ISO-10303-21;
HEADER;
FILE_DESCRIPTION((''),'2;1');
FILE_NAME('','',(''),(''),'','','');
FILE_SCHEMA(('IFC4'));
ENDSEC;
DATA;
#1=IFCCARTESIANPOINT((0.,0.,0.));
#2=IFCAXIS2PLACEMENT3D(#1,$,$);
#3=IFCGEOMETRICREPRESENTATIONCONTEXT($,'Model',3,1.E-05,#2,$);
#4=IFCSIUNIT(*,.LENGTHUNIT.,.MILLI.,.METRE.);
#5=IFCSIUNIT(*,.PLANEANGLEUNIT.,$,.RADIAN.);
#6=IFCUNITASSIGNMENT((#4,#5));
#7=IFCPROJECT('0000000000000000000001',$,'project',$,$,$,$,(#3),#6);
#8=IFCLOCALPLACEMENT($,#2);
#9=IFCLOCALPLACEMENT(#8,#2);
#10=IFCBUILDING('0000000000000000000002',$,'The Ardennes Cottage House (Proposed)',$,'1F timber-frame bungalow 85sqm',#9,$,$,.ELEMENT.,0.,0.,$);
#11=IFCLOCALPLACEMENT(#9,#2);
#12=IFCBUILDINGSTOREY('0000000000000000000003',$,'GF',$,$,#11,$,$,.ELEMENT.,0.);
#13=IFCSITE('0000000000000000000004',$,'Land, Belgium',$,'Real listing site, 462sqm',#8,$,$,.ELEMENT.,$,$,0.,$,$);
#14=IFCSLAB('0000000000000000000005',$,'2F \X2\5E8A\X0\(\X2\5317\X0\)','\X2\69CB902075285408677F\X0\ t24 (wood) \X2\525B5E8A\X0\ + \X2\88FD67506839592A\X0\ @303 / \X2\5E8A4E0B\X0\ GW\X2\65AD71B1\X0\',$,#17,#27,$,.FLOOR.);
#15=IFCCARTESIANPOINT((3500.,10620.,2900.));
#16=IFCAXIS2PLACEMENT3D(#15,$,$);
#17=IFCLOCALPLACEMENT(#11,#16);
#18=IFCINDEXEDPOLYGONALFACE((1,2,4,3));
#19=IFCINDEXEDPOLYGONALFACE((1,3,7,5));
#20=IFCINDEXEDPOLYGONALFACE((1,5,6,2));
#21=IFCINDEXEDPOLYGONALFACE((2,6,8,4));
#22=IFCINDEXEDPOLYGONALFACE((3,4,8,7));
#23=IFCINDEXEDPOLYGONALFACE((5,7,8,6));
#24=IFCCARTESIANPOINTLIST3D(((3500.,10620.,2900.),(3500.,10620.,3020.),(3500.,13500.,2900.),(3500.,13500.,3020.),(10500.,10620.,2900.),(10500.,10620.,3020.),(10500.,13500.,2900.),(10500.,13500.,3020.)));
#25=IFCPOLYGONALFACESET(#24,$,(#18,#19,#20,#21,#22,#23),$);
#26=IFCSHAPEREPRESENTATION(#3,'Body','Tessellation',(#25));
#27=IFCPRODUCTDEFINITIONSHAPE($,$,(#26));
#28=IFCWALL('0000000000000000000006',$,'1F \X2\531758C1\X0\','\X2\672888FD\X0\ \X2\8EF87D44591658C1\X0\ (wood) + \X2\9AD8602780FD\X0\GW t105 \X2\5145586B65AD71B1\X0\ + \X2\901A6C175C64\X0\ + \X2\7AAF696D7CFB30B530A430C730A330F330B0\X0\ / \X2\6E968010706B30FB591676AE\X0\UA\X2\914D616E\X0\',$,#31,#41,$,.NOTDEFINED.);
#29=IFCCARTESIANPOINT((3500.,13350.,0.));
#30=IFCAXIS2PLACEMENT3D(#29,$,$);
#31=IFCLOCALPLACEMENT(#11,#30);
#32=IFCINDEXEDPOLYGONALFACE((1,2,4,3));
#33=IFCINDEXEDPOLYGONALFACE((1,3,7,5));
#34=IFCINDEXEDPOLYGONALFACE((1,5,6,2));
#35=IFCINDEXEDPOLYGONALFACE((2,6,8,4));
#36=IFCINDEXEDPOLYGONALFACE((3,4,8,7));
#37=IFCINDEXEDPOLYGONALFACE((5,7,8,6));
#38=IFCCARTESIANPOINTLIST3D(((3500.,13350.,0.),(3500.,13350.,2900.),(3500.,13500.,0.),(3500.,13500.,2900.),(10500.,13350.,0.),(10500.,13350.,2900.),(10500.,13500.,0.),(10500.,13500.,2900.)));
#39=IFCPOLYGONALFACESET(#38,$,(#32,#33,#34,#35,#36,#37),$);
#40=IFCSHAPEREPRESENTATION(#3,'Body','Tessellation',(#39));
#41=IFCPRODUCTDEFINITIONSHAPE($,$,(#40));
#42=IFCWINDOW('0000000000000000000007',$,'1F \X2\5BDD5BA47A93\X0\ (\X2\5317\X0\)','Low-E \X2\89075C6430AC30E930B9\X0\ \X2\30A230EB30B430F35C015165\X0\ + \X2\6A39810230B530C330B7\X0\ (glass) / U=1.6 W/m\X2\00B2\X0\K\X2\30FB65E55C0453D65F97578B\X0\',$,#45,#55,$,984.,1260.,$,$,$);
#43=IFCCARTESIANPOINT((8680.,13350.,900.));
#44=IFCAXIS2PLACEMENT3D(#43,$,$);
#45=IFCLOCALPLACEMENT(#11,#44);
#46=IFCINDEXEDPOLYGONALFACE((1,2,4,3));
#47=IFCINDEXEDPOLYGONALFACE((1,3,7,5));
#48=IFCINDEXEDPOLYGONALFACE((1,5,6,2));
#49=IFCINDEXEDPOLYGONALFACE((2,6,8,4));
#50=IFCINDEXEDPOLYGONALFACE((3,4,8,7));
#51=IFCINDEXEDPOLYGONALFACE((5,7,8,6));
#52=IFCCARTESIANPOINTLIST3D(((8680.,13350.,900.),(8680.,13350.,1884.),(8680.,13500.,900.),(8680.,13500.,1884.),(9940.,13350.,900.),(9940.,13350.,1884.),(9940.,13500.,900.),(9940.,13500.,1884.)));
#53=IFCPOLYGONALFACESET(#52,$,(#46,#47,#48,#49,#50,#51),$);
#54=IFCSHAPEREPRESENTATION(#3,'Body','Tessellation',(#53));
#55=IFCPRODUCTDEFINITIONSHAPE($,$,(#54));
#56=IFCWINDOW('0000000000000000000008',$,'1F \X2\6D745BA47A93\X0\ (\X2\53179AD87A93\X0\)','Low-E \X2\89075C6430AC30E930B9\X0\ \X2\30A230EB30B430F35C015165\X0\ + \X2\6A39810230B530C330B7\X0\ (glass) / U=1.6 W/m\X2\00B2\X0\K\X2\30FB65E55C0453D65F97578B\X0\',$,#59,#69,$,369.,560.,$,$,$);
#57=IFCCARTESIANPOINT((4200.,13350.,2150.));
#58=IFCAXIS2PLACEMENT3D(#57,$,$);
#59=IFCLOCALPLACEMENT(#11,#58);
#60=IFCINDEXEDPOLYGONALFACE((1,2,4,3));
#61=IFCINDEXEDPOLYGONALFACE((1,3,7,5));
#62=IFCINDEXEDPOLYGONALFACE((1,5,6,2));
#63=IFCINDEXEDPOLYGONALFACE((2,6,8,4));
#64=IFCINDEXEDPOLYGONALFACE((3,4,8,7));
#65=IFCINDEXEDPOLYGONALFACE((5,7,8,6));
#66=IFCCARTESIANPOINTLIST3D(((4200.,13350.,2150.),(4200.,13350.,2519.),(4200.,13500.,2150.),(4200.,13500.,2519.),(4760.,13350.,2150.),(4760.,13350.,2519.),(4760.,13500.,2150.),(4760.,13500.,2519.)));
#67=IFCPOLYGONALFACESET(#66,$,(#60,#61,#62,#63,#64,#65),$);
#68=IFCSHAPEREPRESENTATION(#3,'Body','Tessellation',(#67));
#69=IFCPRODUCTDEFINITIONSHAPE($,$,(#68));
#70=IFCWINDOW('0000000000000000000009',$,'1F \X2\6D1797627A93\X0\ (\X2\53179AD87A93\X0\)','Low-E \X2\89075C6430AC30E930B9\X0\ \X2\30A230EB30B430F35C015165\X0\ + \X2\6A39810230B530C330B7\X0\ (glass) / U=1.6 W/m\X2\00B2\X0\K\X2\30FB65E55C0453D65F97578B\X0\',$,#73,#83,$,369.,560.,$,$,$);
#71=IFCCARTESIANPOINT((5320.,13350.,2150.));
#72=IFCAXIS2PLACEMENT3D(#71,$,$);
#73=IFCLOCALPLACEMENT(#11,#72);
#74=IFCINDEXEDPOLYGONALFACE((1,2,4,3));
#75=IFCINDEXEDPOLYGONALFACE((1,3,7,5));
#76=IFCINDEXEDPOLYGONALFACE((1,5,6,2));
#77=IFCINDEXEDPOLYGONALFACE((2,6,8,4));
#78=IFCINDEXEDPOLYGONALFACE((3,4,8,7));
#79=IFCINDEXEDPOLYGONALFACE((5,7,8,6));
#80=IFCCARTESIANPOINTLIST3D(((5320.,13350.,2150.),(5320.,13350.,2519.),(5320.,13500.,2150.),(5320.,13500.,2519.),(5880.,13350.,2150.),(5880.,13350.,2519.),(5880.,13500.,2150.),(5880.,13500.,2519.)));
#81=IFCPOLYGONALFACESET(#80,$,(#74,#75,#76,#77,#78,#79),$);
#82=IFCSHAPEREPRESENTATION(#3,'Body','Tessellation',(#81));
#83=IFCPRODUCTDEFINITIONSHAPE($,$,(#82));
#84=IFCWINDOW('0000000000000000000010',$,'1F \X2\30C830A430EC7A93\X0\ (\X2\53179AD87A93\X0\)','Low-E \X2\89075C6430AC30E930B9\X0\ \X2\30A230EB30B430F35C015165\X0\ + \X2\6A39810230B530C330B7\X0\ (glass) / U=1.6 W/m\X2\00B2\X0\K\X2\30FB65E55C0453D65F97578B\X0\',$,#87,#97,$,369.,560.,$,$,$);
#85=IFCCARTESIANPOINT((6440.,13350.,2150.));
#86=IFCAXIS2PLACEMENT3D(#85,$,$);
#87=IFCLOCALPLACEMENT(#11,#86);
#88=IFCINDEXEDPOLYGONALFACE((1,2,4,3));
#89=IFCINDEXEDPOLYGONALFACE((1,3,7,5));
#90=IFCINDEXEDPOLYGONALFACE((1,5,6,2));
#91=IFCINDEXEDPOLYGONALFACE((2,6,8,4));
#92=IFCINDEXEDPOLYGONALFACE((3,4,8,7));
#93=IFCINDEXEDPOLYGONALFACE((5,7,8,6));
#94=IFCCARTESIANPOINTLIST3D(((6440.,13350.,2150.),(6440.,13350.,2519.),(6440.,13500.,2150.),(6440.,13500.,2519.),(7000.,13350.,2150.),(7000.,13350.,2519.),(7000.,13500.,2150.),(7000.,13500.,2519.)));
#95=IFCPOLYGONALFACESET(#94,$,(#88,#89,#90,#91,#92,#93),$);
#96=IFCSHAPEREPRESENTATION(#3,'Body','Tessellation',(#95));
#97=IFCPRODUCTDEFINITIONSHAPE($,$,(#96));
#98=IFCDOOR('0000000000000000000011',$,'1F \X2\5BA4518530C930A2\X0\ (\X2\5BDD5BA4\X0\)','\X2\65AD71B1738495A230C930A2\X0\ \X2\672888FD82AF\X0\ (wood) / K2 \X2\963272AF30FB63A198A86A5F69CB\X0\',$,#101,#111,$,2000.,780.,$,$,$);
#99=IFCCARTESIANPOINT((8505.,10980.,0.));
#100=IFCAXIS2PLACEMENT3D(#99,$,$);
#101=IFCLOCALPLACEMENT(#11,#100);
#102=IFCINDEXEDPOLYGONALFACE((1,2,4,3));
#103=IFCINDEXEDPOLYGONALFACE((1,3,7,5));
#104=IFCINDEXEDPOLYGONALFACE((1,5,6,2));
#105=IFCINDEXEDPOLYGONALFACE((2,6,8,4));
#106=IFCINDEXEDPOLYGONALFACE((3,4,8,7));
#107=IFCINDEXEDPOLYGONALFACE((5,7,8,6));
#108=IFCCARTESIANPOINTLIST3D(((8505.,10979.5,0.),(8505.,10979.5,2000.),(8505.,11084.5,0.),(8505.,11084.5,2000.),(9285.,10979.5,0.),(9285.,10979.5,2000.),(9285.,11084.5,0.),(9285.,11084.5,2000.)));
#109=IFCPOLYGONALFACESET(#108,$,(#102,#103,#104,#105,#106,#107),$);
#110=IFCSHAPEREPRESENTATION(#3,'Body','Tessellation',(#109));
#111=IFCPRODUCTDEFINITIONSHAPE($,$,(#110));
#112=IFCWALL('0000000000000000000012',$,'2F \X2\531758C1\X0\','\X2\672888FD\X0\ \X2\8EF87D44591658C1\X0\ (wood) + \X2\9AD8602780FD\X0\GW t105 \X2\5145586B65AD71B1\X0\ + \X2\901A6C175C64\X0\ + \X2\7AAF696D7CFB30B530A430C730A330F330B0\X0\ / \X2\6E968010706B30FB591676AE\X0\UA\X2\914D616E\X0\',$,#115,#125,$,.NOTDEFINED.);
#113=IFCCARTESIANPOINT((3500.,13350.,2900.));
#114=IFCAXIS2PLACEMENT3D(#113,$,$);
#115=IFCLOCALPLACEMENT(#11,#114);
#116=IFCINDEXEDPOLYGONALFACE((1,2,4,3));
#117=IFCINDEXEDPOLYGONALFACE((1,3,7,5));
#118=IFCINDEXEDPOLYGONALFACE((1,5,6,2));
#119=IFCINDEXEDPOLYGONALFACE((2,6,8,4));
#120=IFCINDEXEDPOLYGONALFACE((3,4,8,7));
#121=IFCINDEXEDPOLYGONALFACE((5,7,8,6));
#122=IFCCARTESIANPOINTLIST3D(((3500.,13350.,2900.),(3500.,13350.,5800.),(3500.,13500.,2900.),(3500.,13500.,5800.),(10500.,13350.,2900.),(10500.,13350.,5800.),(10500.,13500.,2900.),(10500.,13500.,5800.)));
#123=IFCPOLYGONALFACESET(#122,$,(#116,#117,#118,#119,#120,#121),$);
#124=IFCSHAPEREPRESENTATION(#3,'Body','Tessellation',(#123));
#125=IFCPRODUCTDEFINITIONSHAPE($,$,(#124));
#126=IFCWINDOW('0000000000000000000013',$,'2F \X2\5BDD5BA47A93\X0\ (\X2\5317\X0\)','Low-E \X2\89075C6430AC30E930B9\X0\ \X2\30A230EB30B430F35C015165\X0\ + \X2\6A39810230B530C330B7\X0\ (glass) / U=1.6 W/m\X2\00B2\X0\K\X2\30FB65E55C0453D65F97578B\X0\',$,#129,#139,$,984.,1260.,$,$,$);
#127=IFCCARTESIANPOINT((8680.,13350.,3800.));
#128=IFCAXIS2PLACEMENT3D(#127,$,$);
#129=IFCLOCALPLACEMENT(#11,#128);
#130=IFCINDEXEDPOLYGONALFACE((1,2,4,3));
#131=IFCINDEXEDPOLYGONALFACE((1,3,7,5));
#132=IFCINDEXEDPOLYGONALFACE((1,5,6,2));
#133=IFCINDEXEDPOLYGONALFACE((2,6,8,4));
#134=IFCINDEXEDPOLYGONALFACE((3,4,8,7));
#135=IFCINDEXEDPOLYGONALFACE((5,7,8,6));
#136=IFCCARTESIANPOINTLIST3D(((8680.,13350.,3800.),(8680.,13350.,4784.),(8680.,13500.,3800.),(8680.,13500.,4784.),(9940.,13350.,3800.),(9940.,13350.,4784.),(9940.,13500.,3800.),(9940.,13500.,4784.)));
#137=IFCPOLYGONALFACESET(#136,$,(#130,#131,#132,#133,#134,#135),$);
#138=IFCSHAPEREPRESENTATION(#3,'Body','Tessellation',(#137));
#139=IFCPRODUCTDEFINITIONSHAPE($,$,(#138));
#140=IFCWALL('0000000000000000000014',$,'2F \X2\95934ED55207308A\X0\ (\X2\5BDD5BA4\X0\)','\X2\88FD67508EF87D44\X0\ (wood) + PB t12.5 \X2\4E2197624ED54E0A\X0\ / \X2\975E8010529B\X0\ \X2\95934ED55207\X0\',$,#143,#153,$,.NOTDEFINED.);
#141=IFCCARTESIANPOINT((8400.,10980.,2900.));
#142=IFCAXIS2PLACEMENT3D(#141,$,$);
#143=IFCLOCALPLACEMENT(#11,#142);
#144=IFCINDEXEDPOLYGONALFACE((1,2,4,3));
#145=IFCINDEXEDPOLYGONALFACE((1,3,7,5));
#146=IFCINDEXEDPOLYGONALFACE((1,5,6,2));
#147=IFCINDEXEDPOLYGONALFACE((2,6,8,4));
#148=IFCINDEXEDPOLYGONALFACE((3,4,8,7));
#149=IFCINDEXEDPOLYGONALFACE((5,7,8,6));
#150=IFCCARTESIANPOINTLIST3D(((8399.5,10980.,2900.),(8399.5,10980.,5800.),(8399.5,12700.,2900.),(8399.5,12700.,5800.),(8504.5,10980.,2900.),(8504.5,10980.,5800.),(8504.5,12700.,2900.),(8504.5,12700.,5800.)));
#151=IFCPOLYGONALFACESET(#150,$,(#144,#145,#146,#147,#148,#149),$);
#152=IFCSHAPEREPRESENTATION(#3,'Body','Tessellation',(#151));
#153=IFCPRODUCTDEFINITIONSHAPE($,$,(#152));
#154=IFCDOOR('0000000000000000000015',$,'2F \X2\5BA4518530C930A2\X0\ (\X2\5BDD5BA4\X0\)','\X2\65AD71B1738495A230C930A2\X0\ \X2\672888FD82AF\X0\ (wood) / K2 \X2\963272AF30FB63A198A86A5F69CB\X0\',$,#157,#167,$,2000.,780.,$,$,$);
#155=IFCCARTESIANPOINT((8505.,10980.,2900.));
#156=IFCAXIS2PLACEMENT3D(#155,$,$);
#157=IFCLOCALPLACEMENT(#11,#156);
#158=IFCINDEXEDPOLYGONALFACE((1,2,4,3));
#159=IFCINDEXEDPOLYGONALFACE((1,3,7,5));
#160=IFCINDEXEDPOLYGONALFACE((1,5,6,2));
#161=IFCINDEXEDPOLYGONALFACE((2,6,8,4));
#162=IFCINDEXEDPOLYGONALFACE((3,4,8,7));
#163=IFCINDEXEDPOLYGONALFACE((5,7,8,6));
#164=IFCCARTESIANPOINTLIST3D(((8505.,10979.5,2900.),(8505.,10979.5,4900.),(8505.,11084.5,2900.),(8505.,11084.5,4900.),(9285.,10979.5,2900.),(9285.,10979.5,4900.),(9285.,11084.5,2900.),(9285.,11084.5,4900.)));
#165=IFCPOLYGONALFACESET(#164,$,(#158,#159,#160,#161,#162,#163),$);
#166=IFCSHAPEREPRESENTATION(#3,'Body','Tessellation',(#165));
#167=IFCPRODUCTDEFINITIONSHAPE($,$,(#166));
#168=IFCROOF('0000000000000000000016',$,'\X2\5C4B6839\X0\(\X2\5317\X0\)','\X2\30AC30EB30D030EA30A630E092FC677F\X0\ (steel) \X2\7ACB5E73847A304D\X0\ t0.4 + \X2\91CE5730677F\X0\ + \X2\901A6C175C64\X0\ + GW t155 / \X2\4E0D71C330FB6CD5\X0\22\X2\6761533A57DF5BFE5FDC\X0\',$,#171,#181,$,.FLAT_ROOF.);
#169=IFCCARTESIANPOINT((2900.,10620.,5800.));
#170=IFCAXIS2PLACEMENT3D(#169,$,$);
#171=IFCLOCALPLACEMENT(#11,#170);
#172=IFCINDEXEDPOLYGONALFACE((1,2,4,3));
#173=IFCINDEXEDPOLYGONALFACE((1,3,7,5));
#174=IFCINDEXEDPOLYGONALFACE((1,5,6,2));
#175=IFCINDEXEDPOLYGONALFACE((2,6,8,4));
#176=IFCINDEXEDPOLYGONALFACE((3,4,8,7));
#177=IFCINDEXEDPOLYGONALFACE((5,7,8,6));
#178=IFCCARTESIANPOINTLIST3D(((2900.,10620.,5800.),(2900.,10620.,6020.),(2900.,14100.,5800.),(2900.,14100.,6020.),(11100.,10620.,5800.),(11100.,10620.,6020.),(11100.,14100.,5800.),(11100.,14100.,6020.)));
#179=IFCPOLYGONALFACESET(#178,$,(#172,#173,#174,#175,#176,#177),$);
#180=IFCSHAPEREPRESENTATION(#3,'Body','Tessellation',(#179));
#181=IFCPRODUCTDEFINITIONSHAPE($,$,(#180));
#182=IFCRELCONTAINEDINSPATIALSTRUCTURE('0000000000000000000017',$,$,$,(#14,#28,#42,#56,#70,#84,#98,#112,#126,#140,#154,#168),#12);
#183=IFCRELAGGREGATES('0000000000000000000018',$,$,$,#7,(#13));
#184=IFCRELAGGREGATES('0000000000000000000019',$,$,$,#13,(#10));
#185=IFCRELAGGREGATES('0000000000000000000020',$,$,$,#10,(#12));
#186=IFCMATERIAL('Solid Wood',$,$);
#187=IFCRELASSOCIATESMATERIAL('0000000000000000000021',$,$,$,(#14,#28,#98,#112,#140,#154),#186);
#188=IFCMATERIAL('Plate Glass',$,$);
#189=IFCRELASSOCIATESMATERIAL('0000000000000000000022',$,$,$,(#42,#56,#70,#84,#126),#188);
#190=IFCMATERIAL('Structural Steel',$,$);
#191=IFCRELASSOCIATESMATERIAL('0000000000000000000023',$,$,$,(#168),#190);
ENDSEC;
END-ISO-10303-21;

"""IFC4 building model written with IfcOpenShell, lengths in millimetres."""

from ifc_helpers import new_model, si_unit, frame, frame_2d, origin, place, context, project, spatial, rectangle, extrude, material, element, fill, save


model = new_model("IFC4")

# Units and contexts
model_context = context("Model", 3, precision=1e-05, world=origin())
ifc_project = project(units=[si_unit("LENGTHUNIT", "METRE", prefix="MILLI"), si_unit("PLANEANGLEUNIT", "RADIAN")], contexts=[model_context])

# Site, building, storey
site_placement = place(None, origin())
site = spatial("IfcSite", under=ifc_project, at=site_placement, Name="Land, Belgium", ObjectType="Real listing site, 462sqm", CompositionType="ELEMENT", RefElevation=0.0)
building_placement = place(site_placement, origin())
building = spatial("IfcBuilding", under=site, at=building_placement, Name="The Ardennes Cottage House (Proposed)", ObjectType="1F timber-frame bungalow 85sqm", CompositionType="ELEMENT", ElevationOfRefHeight=0.0, ElevationOfTerrain=0.0)
storey_placement = place(building_placement, origin())
storey = spatial("IfcBuildingStorey", under=building, at=storey_placement, Name="GF", CompositionType="ELEMENT", Elevation=0.0)

# Slab
ifc_material_1 = material(Name="Solid Wood")
slab_placement = place(storey_placement, frame((3500.0, 10620.0, 2900.0)))
element("IfcSlab", 1, at=slab_placement, inside=storey, material=ifc_material_1, Name="2F 床(北)", Description="構造用合板 t24 (wood) 剛床 + 製材根太 @303 / 床下 GW断熱", PredefinedType="FLOOR", context=model_context, shape_type="SweptSolid", body=[
    extrude(rectangle(XDim=7000.0, YDim=2880.0, at=frame_2d((3500.0, 1440.0))), frame((3500.0, 10620.0, 2900.0)), (0.0, 0.0, 1.0), 120.0),
])

# Wall, openings, windows
wall_1_placement = place(storey_placement, frame((3500.0, 13350.0, 0.0)))
wall_1 = element("IfcWall", 2, at=wall_1_placement, inside=storey, material=ifc_material_1, Name="1F 北壁", Description="木製 軸組外壁 (wood) + 高性能GW t105 充填断熱 + 通気層 + 窯業系サイディング / 準耐火・外皮UA配慮", PredefinedType="NOTDEFINED", context=model_context, shape_type="SweptSolid", body=[
    extrude(rectangle(XDim=7000.0, YDim=150.0, at=frame_2d((3500.0, 75.0))), frame((3500.0, 13350.0, 0.0)), (0.0, 0.0, 1.0), 2900.0),
])
opening_1_placement = place(storey_placement, frame((8680.0, 13350.0, 900.0)))
opening_1 = element("IfcOpeningElement", 3, at=opening_1_placement, cuts=wall_1, PredefinedType="NOTDEFINED", context=model_context, shape_type="SweptSolid", body=[
    extrude(rectangle(XDim=1260.0, YDim=150.0, at=frame_2d((630.0, 75.0))), frame((8680.0, 13350.0, 900.0)), (0.0, 0.0, 1.0), 984.0),
])
opening_2_placement = place(storey_placement, frame((4200.0, 13350.0, 2150.0)))
opening_2 = element("IfcOpeningElement", 4, at=opening_2_placement, cuts=wall_1, PredefinedType="NOTDEFINED", context=model_context, shape_type="SweptSolid", body=[
    extrude(rectangle(XDim=560.0, YDim=150.0, at=frame_2d((280.0, 75.0))), frame((4200.0, 13350.0, 2150.0)), (0.0, 0.0, 1.0), 369.0),
])
opening_3_placement = place(storey_placement, frame((5320.0, 13350.0, 2150.0)))
opening_3 = element("IfcOpeningElement", 5, at=opening_3_placement, cuts=wall_1, PredefinedType="NOTDEFINED", context=model_context, shape_type="SweptSolid", body=[
    extrude(rectangle(XDim=560.0, YDim=150.0, at=frame_2d((280.0, 75.0))), frame((5320.0, 13350.0, 2150.0)), (0.0, 0.0, 1.0), 369.0),
])
opening_4_placement = place(storey_placement, frame((6440.0, 13350.0, 2150.0)))
opening_4 = element("IfcOpeningElement", 6, at=opening_4_placement, cuts=wall_1, PredefinedType="NOTDEFINED", context=model_context, shape_type="SweptSolid", body=[
    extrude(rectangle(XDim=560.0, YDim=150.0, at=frame_2d((280.0, 75.0))), frame((6440.0, 13350.0, 2150.0)), (0.0, 0.0, 1.0), 369.0),
])
ifc_material_2 = material(Name="Plate Glass")
window_1_placement = place(storey_placement, frame((8680.0, 13350.0, 900.0)))
window_1 = element("IfcWindow", 7, at=window_1_placement, inside=storey, material=ifc_material_2, Name="1F 寝室窓 (北)", Description="Low-E 複層ガラス アルゴン封入 + 樹脂サッシ (glass) / U=1.6 W/m²K・日射取得型", OverallHeight=984.0, OverallWidth=1260.0, context=model_context, shape_type="SweptSolid", body=[
    extrude(rectangle(XDim=1260.0, YDim=150.0, at=frame_2d((630.0, 75.0))), frame((8680.0, 13350.0, 900.0)), (0.0, 0.0, 1.0), 984.0),
])
fill(opening_1, window_1)
window_2_placement = place(storey_placement, frame((4200.0, 13350.0, 2150.0)))
window_2 = element("IfcWindow", 8, at=window_2_placement, inside=storey, material=ifc_material_2, Name="1F 浴室窓 (北高窓)", Description="Low-E 複層ガラス アルゴン封入 + 樹脂サッシ (glass) / U=1.6 W/m²K・日射取得型", OverallHeight=369.0, OverallWidth=560.0, context=model_context, shape_type="SweptSolid", body=[
    extrude(rectangle(XDim=560.0, YDim=150.0, at=frame_2d((280.0, 75.0))), frame((4200.0, 13350.0, 2150.0)), (0.0, 0.0, 1.0), 369.0),
])
fill(opening_2, window_2)
window_3_placement = place(storey_placement, frame((5320.0, 13350.0, 2150.0)))
window_3 = element("IfcWindow", 9, at=window_3_placement, inside=storey, material=ifc_material_2, Name="1F 洗面窓 (北高窓)", Description="Low-E 複層ガラス アルゴン封入 + 樹脂サッシ (glass) / U=1.6 W/m²K・日射取得型", OverallHeight=369.0, OverallWidth=560.0, context=model_context, shape_type="SweptSolid", body=[
    extrude(rectangle(XDim=560.0, YDim=150.0, at=frame_2d((280.0, 75.0))), frame((5320.0, 13350.0, 2150.0)), (0.0, 0.0, 1.0), 369.0),
])
fill(opening_3, window_3)
window_4_placement = place(storey_placement, frame((6440.0, 13350.0, 2150.0)))
window_4 = element("IfcWindow", 10, at=window_4_placement, inside=storey, material=ifc_material_2, Name="1F トイレ窓 (北高窓)", Description="Low-E 複層ガラス アルゴン封入 + 樹脂サッシ (glass) / U=1.6 W/m²K・日射取得型", OverallHeight=369.0, OverallWidth=560.0, context=model_context, shape_type="SweptSolid", body=[
    extrude(rectangle(XDim=560.0, YDim=150.0, at=frame_2d((280.0, 75.0))), frame((6440.0, 13350.0, 2150.0)), (0.0, 0.0, 1.0), 369.0),
])
fill(opening_4, window_4)

# Door
door_1_placement = place(storey_placement, frame((8505.0, 10980.0, 0.0)))
element("IfcDoor", 11, at=door_1_placement, inside=storey, material=ifc_material_1, Name="1F 室内ドア (寝室)", Description="断熱玄関ドア 木製芯 (wood) / K2 防犯・採風機構", OverallHeight=2000.0, OverallWidth=780.0, context=model_context, shape_type="SweptSolid", body=[
    extrude(rectangle(XDim=780.0, YDim=105.0, at=frame_2d((390.0, 52.0))), frame((8505.0, 10980.0, 0.0)), (0.0, 0.0, 1.0), 2000.0),
])

# Wall, opening, window
wall_2_placement = place(storey_placement, frame((3500.0, 13350.0, 2900.0)))
wall_2 = element("IfcWall", 12, at=wall_2_placement, inside=storey, material=ifc_material_1, Name="2F 北壁", Description="木製 軸組外壁 (wood) + 高性能GW t105 充填断熱 + 通気層 + 窯業系サイディング / 準耐火・外皮UA配慮", PredefinedType="NOTDEFINED", context=model_context, shape_type="SweptSolid", body=[
    extrude(rectangle(XDim=7000.0, YDim=150.0, at=frame_2d((3500.0, 75.0))), frame((3500.0, 13350.0, 2900.0)), (0.0, 0.0, 1.0), 2900.0),
])
opening_5_placement = place(storey_placement, frame((8680.0, 13350.0, 3800.0)))
opening_5 = element("IfcOpeningElement", 13, at=opening_5_placement, cuts=wall_2, PredefinedType="NOTDEFINED", context=model_context, shape_type="SweptSolid", body=[
    extrude(rectangle(XDim=1260.0, YDim=150.0, at=frame_2d((630.0, 75.0))), frame((8680.0, 13350.0, 3800.0)), (0.0, 0.0, 1.0), 984.0),
])
window_5_placement = place(storey_placement, frame((8680.0, 13350.0, 3800.0)))
window_5 = element("IfcWindow", 14, at=window_5_placement, inside=storey, material=ifc_material_2, Name="2F 寝室窓 (北)", Description="Low-E 複層ガラス アルゴン封入 + 樹脂サッシ (glass) / U=1.6 W/m²K・日射取得型", OverallHeight=984.0, OverallWidth=1260.0, context=model_context, shape_type="SweptSolid", body=[
    extrude(rectangle(XDim=1260.0, YDim=150.0, at=frame_2d((630.0, 75.0))), frame((8680.0, 13350.0, 3800.0)), (0.0, 0.0, 1.0), 984.0),
])
fill(opening_5, window_5)

# Wall
wall_3_placement = place(storey_placement, frame((8400.0, 10980.0, 2900.0)))
element("IfcWall", 15, at=wall_3_placement, inside=storey, material=ifc_material_1, Name="2F 間仕切り (寝室)", Description="製材軸組 (wood) + PB t12.5 両面仕上 / 非耐力 間仕切", PredefinedType="NOTDEFINED", context=model_context, shape_type="SweptSolid", body=[
    extrude(rectangle(XDim=105.0, YDim=1720.0, at=frame_2d((52.0, 860.0))), frame((8400.0, 10980.0, 2900.0)), (0.0, 0.0, 1.0), 2900.0),
])

# Door
door_2_placement = place(storey_placement, frame((8505.0, 10980.0, 2900.0)))
element("IfcDoor", 16, at=door_2_placement, inside=storey, material=ifc_material_1, Name="2F 室内ドア (寝室)", Description="断熱玄関ドア 木製芯 (wood) / K2 防犯・採風機構", OverallHeight=2000.0, OverallWidth=780.0, context=model_context, shape_type="SweptSolid", body=[
    extrude(rectangle(XDim=780.0, YDim=105.0, at=frame_2d((390.0, 52.0))), frame((8505.0, 10980.0, 2900.0)), (0.0, 0.0, 1.0), 2000.0),
])

# Roof
ifc_material_3 = material(Name="Structural Steel")
roof_placement = place(storey_placement, frame((2900.0, 10620.0, 5800.0)))
element("IfcRoof", 17, at=roof_placement, inside=storey, material=ifc_material_3, Name="屋根(北)", Description="ガルバリウム鋼板 (steel) 立平葺き t0.4 + 野地板 + 通気層 + GW t155 / 不燃・法22条区域対応", PredefinedType="FLAT_ROOF", context=model_context, shape_type="SweptSolid", body=[
    extrude(rectangle(XDim=8200.0, YDim=3480.0, at=frame_2d((4100.0, 1740.0))), frame((2900.0, 10620.0, 5800.0)), (0.0, 0.0, 1.0), 220.0),
])

save(model, "model.ifc")
